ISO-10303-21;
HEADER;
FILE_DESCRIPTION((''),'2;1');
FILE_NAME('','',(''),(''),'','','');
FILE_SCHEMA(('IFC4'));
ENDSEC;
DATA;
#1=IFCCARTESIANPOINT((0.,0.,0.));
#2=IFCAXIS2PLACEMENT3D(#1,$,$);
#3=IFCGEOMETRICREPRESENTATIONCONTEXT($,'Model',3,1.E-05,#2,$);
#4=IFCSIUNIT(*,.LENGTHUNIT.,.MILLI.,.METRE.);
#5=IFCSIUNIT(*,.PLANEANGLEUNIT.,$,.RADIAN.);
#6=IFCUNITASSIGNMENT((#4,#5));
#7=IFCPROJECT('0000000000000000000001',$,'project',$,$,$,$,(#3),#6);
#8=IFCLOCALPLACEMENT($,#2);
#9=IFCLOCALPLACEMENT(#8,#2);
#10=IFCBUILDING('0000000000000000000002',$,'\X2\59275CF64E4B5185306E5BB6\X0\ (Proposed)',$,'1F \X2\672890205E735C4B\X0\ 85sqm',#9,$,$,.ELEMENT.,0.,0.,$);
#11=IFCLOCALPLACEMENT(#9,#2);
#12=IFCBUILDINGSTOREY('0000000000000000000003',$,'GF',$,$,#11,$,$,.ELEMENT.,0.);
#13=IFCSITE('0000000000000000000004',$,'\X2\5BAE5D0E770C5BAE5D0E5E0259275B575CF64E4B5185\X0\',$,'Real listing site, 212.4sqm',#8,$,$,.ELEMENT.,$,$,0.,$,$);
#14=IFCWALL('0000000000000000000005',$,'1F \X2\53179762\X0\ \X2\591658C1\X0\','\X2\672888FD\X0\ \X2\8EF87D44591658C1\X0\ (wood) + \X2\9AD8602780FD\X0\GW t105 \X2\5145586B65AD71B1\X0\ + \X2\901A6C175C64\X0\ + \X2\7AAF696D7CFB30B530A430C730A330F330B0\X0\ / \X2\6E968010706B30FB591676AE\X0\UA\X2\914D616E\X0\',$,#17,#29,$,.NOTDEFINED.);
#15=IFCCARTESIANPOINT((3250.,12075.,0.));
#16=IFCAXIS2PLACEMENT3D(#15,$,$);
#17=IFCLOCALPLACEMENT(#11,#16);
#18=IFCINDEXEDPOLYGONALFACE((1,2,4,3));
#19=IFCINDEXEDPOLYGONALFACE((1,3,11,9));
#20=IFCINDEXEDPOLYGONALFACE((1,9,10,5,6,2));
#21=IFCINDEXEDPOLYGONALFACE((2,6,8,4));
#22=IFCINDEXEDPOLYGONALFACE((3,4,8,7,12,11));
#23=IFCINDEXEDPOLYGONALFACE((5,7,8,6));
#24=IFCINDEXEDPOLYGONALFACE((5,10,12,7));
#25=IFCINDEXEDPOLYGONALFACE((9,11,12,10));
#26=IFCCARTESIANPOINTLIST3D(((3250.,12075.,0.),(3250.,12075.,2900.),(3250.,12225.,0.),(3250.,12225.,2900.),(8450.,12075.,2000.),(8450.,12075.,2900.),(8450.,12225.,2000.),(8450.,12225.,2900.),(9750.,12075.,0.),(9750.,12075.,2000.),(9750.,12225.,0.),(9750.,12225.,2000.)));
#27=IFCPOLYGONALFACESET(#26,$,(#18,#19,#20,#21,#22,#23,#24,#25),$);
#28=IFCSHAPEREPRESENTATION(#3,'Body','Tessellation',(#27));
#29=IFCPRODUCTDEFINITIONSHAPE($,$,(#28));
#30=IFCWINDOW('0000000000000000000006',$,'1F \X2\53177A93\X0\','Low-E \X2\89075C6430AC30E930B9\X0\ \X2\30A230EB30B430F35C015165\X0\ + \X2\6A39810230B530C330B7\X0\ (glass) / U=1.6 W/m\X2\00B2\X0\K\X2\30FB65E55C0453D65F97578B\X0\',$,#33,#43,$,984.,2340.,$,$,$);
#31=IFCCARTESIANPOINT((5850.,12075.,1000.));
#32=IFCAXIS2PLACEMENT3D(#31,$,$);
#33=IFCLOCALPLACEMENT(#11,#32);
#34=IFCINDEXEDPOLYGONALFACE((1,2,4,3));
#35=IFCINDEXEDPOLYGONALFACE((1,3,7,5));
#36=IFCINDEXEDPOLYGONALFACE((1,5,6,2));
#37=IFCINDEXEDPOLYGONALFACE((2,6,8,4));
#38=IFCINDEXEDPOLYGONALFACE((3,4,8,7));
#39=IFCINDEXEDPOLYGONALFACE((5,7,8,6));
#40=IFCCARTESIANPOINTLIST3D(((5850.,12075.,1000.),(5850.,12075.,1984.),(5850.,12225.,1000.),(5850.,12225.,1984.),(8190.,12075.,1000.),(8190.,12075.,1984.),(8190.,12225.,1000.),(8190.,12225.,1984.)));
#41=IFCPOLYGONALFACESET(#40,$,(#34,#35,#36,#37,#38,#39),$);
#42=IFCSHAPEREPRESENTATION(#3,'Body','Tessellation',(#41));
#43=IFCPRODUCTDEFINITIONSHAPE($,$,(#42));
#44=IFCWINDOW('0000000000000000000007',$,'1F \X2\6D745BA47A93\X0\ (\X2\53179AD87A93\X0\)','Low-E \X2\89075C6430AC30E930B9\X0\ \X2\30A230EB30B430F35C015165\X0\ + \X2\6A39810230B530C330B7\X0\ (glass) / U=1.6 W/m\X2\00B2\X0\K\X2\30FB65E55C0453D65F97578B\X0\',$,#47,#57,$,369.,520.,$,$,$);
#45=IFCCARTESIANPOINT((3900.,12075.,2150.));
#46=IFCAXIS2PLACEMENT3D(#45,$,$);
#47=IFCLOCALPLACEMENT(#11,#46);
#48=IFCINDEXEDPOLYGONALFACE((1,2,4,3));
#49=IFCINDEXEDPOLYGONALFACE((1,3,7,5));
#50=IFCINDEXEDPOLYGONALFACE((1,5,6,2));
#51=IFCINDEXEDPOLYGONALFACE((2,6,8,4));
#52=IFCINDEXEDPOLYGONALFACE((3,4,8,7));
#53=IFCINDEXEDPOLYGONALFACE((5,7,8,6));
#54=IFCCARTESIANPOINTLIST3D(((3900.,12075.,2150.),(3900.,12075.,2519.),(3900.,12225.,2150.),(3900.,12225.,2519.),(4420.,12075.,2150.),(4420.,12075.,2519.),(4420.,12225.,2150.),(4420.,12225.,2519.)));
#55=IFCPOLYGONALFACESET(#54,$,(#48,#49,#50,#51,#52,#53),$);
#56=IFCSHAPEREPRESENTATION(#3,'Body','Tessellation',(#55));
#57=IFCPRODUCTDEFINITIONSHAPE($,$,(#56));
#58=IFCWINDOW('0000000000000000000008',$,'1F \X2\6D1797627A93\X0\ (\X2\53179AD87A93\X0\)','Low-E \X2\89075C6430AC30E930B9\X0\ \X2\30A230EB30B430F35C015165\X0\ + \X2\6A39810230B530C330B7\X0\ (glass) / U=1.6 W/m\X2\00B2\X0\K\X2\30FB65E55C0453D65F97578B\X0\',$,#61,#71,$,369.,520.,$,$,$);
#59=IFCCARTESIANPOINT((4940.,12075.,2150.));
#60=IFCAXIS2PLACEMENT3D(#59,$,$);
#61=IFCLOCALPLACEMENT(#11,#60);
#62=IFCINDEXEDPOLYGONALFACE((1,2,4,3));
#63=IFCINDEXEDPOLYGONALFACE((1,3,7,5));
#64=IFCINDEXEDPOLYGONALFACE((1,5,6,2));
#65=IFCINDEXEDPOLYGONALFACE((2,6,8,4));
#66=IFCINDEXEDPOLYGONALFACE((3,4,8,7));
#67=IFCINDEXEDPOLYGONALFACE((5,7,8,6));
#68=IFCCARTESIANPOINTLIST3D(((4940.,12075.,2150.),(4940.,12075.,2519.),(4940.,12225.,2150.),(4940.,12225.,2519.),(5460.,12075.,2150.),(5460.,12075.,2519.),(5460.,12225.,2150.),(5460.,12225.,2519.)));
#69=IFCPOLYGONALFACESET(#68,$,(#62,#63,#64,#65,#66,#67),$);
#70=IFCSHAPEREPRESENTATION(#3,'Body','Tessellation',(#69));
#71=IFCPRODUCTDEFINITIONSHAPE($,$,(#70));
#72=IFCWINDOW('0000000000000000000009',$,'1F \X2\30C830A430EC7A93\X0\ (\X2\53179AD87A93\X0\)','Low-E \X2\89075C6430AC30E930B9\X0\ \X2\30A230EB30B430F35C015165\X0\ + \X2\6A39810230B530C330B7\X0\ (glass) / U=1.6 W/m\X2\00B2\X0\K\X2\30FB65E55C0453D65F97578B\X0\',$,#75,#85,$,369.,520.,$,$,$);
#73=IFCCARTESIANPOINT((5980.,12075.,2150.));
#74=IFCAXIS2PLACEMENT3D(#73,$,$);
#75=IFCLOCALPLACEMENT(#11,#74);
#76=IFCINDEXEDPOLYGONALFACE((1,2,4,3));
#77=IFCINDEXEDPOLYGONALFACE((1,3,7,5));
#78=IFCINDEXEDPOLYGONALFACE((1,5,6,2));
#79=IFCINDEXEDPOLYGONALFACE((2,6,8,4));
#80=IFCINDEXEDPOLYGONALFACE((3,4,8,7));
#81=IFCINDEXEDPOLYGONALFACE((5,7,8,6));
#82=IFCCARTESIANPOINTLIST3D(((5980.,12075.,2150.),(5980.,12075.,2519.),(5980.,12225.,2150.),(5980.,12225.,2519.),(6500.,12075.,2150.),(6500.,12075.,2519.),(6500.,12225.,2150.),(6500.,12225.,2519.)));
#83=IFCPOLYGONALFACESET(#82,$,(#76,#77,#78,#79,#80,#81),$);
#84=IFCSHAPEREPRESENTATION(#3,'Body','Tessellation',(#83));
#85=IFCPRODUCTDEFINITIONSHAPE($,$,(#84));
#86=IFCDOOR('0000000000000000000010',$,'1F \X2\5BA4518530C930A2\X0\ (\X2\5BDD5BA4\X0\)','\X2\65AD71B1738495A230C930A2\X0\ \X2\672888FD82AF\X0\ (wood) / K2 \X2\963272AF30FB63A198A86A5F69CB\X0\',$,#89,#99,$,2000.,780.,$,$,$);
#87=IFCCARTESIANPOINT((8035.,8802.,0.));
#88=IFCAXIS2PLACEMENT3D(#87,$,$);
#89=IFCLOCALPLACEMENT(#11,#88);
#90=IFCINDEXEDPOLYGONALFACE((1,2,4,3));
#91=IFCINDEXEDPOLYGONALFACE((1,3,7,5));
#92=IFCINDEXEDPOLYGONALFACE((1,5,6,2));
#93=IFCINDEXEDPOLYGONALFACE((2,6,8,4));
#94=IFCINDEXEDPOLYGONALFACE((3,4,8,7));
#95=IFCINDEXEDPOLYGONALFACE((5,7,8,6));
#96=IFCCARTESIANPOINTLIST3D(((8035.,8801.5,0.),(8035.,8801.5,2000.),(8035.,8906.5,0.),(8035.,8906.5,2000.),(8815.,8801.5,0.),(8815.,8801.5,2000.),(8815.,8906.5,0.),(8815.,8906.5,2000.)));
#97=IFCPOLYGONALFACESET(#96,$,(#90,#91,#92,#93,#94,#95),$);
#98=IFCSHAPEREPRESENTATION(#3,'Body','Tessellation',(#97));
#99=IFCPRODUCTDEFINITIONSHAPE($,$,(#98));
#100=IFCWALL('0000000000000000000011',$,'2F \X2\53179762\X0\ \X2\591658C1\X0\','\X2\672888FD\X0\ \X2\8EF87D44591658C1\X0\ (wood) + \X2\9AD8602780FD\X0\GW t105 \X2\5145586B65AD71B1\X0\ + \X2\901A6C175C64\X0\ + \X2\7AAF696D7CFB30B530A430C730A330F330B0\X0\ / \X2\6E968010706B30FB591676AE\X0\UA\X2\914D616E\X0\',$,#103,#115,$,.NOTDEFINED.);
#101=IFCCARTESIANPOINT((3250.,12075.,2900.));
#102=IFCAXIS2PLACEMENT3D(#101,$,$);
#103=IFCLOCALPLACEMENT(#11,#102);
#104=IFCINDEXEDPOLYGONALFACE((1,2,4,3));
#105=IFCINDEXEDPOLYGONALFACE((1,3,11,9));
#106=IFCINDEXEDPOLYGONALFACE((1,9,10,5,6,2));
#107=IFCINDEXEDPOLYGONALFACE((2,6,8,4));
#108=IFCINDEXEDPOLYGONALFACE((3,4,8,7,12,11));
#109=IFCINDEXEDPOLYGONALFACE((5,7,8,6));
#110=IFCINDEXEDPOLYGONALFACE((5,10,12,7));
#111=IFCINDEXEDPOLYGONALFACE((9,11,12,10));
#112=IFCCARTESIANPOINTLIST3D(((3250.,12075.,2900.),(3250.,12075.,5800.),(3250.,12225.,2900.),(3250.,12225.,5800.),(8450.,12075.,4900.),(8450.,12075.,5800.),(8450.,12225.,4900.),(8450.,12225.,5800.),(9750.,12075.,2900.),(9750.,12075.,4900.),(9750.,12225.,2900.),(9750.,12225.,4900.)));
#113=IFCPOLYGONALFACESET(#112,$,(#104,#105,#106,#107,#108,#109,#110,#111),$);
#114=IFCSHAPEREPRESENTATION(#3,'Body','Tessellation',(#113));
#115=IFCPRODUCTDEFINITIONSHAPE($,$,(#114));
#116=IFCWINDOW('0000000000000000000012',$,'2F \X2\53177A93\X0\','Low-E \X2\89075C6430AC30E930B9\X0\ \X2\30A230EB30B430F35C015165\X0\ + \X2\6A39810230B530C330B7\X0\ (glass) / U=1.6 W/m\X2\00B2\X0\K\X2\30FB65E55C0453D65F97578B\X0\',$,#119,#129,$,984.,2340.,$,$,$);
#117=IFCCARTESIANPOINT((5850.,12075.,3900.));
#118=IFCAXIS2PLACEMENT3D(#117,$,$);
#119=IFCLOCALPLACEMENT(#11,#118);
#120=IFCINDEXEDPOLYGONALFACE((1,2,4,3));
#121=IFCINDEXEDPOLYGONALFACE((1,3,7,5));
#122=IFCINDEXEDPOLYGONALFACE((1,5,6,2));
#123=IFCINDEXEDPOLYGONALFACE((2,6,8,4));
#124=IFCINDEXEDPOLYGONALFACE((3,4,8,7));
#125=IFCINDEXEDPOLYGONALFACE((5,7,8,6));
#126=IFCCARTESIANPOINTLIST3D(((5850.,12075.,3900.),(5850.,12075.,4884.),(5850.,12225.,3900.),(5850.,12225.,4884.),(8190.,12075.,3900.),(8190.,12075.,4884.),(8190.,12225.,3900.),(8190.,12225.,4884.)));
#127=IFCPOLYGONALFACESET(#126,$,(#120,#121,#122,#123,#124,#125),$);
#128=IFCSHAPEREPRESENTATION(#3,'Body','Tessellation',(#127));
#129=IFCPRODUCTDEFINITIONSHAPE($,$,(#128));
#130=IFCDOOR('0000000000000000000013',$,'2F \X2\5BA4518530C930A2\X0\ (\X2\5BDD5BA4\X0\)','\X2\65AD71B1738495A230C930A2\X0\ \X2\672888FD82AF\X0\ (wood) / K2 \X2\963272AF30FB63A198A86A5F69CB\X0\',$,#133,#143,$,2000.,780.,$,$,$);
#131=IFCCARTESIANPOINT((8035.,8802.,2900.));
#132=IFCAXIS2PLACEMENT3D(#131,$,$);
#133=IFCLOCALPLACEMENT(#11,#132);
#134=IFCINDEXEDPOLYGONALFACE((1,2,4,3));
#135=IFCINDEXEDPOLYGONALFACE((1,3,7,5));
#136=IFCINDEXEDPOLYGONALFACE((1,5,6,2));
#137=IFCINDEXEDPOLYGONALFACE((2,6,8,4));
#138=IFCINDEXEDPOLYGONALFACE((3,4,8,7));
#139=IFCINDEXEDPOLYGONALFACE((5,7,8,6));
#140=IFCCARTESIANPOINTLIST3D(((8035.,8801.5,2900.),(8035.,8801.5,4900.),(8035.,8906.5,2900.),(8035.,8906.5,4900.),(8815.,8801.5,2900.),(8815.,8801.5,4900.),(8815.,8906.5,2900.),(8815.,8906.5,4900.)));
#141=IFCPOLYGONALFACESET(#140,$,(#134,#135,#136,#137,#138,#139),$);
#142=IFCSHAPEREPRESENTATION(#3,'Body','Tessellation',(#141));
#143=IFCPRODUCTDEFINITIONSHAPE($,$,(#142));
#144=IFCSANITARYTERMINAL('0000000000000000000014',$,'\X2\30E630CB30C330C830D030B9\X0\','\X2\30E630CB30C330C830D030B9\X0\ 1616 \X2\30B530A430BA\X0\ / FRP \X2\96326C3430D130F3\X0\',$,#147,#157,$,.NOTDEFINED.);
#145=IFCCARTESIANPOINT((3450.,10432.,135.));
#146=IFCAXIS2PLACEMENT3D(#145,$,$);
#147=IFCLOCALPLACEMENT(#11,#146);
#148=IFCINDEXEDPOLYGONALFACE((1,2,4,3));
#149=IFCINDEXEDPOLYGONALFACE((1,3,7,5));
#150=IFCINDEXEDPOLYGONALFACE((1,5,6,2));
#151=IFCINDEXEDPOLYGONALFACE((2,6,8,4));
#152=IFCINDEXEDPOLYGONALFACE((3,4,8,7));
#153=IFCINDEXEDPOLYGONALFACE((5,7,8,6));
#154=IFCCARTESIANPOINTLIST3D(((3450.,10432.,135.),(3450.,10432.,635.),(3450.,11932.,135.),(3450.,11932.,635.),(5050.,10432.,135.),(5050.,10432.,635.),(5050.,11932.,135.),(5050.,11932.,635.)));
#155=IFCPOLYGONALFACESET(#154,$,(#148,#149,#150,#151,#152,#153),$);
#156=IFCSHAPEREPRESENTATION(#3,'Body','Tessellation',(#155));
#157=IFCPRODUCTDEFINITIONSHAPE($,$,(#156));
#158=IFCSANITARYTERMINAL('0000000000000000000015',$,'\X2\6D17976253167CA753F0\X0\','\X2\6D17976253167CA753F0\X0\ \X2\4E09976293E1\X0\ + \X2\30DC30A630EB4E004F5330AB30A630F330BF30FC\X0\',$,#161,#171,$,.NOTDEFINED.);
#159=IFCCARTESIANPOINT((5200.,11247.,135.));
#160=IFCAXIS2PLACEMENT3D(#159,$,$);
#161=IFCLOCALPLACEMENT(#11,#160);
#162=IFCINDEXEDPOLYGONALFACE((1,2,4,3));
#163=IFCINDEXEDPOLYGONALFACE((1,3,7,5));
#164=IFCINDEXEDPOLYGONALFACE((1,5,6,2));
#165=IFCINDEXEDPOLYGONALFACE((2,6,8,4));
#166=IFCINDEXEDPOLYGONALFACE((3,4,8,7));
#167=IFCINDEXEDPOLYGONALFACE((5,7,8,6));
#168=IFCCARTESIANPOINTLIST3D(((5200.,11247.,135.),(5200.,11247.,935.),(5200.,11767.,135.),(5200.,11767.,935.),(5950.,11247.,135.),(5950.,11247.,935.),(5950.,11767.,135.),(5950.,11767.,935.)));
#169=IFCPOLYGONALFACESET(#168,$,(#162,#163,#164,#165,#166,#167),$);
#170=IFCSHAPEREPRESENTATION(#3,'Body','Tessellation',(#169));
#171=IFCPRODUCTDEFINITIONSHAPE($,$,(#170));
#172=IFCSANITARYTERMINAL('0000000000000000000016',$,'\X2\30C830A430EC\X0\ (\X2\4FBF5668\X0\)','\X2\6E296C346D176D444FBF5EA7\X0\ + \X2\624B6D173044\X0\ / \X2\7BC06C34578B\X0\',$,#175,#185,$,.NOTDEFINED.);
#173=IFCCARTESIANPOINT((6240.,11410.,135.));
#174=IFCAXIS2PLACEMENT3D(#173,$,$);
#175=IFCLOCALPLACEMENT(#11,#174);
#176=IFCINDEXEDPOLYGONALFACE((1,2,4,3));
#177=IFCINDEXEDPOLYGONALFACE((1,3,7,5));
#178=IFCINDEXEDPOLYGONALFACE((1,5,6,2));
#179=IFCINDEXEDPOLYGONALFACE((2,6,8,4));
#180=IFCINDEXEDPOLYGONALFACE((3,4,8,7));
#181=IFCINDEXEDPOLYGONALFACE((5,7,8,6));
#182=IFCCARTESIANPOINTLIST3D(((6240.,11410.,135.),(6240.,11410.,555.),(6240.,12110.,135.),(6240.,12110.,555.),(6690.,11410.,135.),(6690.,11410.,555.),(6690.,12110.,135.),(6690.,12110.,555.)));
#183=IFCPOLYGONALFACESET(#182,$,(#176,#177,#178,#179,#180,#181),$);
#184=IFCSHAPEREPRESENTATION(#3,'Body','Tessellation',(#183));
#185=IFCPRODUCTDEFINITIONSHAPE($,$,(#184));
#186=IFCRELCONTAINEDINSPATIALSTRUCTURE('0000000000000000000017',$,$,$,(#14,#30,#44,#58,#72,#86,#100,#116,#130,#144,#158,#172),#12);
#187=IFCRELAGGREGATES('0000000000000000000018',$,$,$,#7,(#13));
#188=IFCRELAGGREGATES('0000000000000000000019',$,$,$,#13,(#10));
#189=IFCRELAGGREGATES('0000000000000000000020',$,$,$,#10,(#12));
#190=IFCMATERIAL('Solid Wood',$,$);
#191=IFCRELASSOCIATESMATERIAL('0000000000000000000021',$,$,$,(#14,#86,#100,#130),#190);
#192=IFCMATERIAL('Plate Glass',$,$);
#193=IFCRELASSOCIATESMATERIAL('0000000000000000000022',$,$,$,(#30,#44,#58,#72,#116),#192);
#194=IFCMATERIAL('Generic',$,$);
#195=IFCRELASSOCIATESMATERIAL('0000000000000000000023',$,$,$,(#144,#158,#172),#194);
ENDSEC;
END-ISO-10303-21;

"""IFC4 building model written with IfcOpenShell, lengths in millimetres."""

from ifc_helpers import new_model, si_unit, frame, frame_2d, origin, place, context, project, spatial, rectangle, extrude, material, element, fill, save


model = new_model("IFC4")

# Units and contexts
model_context = context("Model", 3, precision=1e-05, world=origin())
ifc_project = project(units=[si_unit("LENGTHUNIT", "METRE", prefix="MILLI"), si_unit("PLANEANGLEUNIT", "RADIAN")], contexts=[model_context])

# Site, building, storey
site_placement = place(None, origin())
site = spatial("IfcSite", under=ifc_project, at=site_placement, Name="宮崎県宮崎市大字島之内", ObjectType="Real listing site, 212.4sqm", CompositionType="ELEMENT", RefElevation=0.0)
building_placement = place(site_placement, origin())
building = spatial("IfcBuilding", under=site, at=building_placement, Name="大島之内の家 (Proposed)", ObjectType="1F 木造平屋 85sqm", CompositionType="ELEMENT", ElevationOfRefHeight=0.0, ElevationOfTerrain=0.0)
storey_placement = place(building_placement, origin())
storey = spatial("IfcBuildingStorey", under=building, at=storey_placement, Name="GF", CompositionType="ELEMENT", Elevation=0.0)

# Wall, openings, windows
ifc_material_1 = material(Name="Solid Wood")
wall_1_placement = place(storey_placement, frame((3250.0, 12075.0, 0.0)))
wall_1 = element("IfcWall", 1, at=wall_1_placement, inside=storey, material=ifc_material_1, Name="1F 北面 外壁", Description="木製 軸組外壁 (wood) + 高性能GW t105 充填断熱 + 通気層 + 窯業系サイディング / 準耐火・外皮UA配慮", PredefinedType="NOTDEFINED", context=model_context, shape_type="SweptSolid", body=[
    extrude(rectangle(XDim=6500.0, YDim=150.0, at=frame_2d((3250.0, 75.0))), frame((3250.0, 12075.0, 0.0)), (0.0, 0.0, 1.0), 2900.0),
])
opening_1_placement = place(storey_placement, frame((5850.0, 12075.0, 1000.0)))
opening_1 = element("IfcOpeningElement", 2, at=opening_1_placement, cuts=wall_1, PredefinedType="NOTDEFINED", context=model_context, shape_type="SweptSolid", body=[
    extrude(rectangle(XDim=2340.0, YDim=150.0, at=frame_2d((1170.0, 75.0))), frame((5850.0, 12075.0, 1000.0)), (0.0, 0.0, 1.0), 984.0),
])
opening_2_placement = place(storey_placement, frame((3900.0, 12075.0, 2150.0)))
opening_2 = element("IfcOpeningElement", 3, at=opening_2_placement, cuts=wall_1, PredefinedType="NOTDEFINED", context=model_context, shape_type="SweptSolid", body=[
    extrude(rectangle(XDim=520.0, YDim=150.0, at=frame_2d((260.0, 75.0))), frame((3900.0, 12075.0, 2150.0)), (0.0, 0.0, 1.0), 369.0),
])
opening_3_placement = place(storey_placement, frame((4940.0, 12075.0, 2150.0)))
opening_3 = element("IfcOpeningElement", 4, at=opening_3_placement, cuts=wall_1, PredefinedType="NOTDEFINED", context=model_context, shape_type="SweptSolid", body=[
    extrude(rectangle(XDim=520.0, YDim=150.0, at=frame_2d((260.0, 75.0))), frame((4940.0, 12075.0, 2150.0)), (0.0, 0.0, 1.0), 369.0),
])
opening_4_placement = place(storey_placement, frame((5980.0, 12075.0, 2150.0)))
opening_4 = element("IfcOpeningElement", 5, at=opening_4_placement, cuts=wall_1, PredefinedType="NOTDEFINED", context=model_context, shape_type="SweptSolid", body=[
    extrude(rectangle(XDim=520.0, YDim=150.0, at=frame_2d((260.0, 75.0))), frame((5980.0, 12075.0, 2150.0)), (0.0, 0.0, 1.0), 369.0),
])
ifc_material_2 = material(Name="Plate Glass")
window_1_placement = place(storey_placement, frame((5850.0, 12075.0, 1000.0)))
window_1 = element("IfcWindow", 6, at=window_1_placement, inside=storey, material=ifc_material_2, Name="1F 北窓", Description="Low-E 複層ガラス アルゴン封入 + 樹脂サッシ (glass) / U=1.6 W/m²K・日射取得型", OverallHeight=984.0, OverallWidth=2340.0, context=model_context, shape_type="SweptSolid", body=[
    extrude(rectangle(XDim=2340.0, YDim=150.0, at=frame_2d((1170.0, 75.0))), frame((5850.0, 12075.0, 1000.0)), (0.0, 0.0, 1.0), 984.0),
])
fill(opening_1, window_1)
window_2_placement = place(storey_placement, frame((3900.0, 12075.0, 2150.0)))
window_2 = element("IfcWindow", 7, at=window_2_placement, inside=storey, material=ifc_material_2, Name="1F 浴室窓 (北高窓)", Description="Low-E 複層ガラス アルゴン封入 + 樹脂サッシ (glass) / U=1.6 W/m²K・日射取得型", OverallHeight=369.0, OverallWidth=520.0, context=model_context, shape_type="SweptSolid", body=[
    extrude(rectangle(XDim=520.0, YDim=150.0, at=frame_2d((260.0, 75.0))), frame((3900.0, 12075.0, 2150.0)), (0.0, 0.0, 1.0), 369.0),
])
fill(opening_2, window_2)
window_3_placement = place(storey_placement, frame((4940.0, 12075.0, 2150.0)))
window_3 = element("IfcWindow", 8, at=window_3_placement, inside=storey, material=ifc_material_2, Name="1F 洗面窓 (北高窓)", Description="Low-E 複層ガラス アルゴン封入 + 樹脂サッシ (glass) / U=1.6 W/m²K・日射取得型", OverallHeight=369.0, OverallWidth=520.0, context=model_context, shape_type="SweptSolid", body=[
    extrude(rectangle(XDim=520.0, YDim=150.0, at=frame_2d((260.0, 75.0))), frame((4940.0, 12075.0, 2150.0)), (0.0, 0.0, 1.0), 369.0),
])
fill(opening_3, window_3)
window_4_placement = place(storey_placement, frame((5980.0, 12075.0, 2150.0)))
window_4 = element("IfcWindow", 9, at=window_4_placement, inside=storey, material=ifc_material_2, Name="1F トイレ窓 (北高窓)", Description="Low-E 複層ガラス アルゴン封入 + 樹脂サッシ (glass) / U=1.6 W/m²K・日射取得型", OverallHeight=369.0, OverallWidth=520.0, context=model_context, shape_type="SweptSolid", body=[
    extrude(rectangle(XDim=520.0, YDim=150.0, at=frame_2d((260.0, 75.0))), frame((5980.0, 12075.0, 2150.0)), (0.0, 0.0, 1.0), 369.0),
])
fill(opening_4, window_4)

# Door
door_1_placement = place(storey_placement, frame((8035.0, 8802.0, 0.0)))
element("IfcDoor", 10, at=door_1_placement, inside=storey, material=ifc_material_1, Name="1F 室内ドア (寝室)", Description="断熱玄関ドア 木製芯 (wood) / K2 防犯・採風機構", OverallHeight=2000.0, OverallWidth=780.0, context=model_context, shape_type="SweptSolid", body=[
    extrude(rectangle(XDim=780.0, YDim=105.0, at=frame_2d((390.0, 52.0))), frame((8035.0, 8802.0, 0.0)), (0.0, 0.0, 1.0), 2000.0),
])

# Wall, opening, window
wall_2_placement = place(storey_placement, frame((3250.0, 12075.0, 2900.0)))
wall_2 = element("IfcWall", 11, at=wall_2_placement, inside=storey, material=ifc_material_1, Name="2F 北面 外壁", Description="木製 軸組外壁 (wood) + 高性能GW t105 充填断熱 + 通気層 + 窯業系サイディング / 準耐火・外皮UA配慮", PredefinedType="NOTDEFINED", context=model_context, shape_type="SweptSolid", body=[
    extrude(rectangle(XDim=6500.0, YDim=150.0, at=frame_2d((3250.0, 75.0))), frame((3250.0, 12075.0, 2900.0)), (0.0, 0.0, 1.0), 2900.0),
])
opening_5_placement = place(storey_placement, frame((5850.0, 12075.0, 3900.0)))
opening_5 = element("IfcOpeningElement", 12, at=opening_5_placement, cuts=wall_2, PredefinedType="NOTDEFINED", context=model_context, shape_type="SweptSolid", body=[
    extrude(rectangle(XDim=2340.0, YDim=150.0, at=frame_2d((1170.0, 75.0))), frame((5850.0, 12075.0, 3900.0)), (0.0, 0.0, 1.0), 984.0),
])
window_5_placement = place(storey_placement, frame((5850.0, 12075.0, 3900.0)))
window_5 = element("IfcWindow", 13, at=window_5_placement, inside=storey, material=ifc_material_2, Name="2F 北窓", Description="Low-E 複層ガラス アルゴン封入 + 樹脂サッシ (glass) / U=1.6 W/m²K・日射取得型", OverallHeight=984.0, OverallWidth=2340.0, context=model_context, shape_type="SweptSolid", body=[
    extrude(rectangle(XDim=2340.0, YDim=150.0, at=frame_2d((1170.0, 75.0))), frame((5850.0, 12075.0, 3900.0)), (0.0, 0.0, 1.0), 984.0),
])
fill(opening_5, window_5)

# Door
door_2_placement = place(storey_placement, frame((8035.0, 8802.0, 2900.0)))
element("IfcDoor", 14, at=door_2_placement, inside=storey, material=ifc_material_1, Name="2F 室内ドア (寝室)", Description="断熱玄関ドア 木製芯 (wood) / K2 防犯・採風機構", OverallHeight=2000.0, OverallWidth=780.0, context=model_context, shape_type="SweptSolid", body=[
    extrude(rectangle(XDim=780.0, YDim=105.0, at=frame_2d((390.0, 52.0))), frame((8035.0, 8802.0, 2900.0)), (0.0, 0.0, 1.0), 2000.0),
])

# Sanitary terminals
ifc_material_3 = material(Name="Generic")
sanitary_terminal_1_placement = place(storey_placement, frame((3450.0, 10432.0, 135.0)))
element("IfcSanitaryTerminal", 15, at=sanitary_terminal_1_placement, inside=storey, material=ifc_material_3, Name="ユニットバス", Description="ユニットバス 1616 サイズ / FRP 防水パン", PredefinedType="NOTDEFINED", context=model_context, shape_type="SweptSolid", body=[
    extrude(rectangle(XDim=1600.0, YDim=1500.0, at=frame_2d((800.0, 750.0))), frame((3450.0, 10432.0, 135.0)), (0.0, 0.0, 1.0), 500.0),
])
sanitary_terminal_2_placement = place(storey_placement, frame((5200.0, 11247.0, 135.0)))
element("IfcSanitaryTerminal", 16, at=sanitary_terminal_2_placement, inside=storey, material=ifc_material_3, Name="洗面化粧台", Description="洗面化粧台 三面鏡 + ボウル一体カウンター", PredefinedType="NOTDEFINED", context=model_context, shape_type="SweptSolid", body=[
    extrude(rectangle(XDim=750.0, YDim=520.0, at=frame_2d((375.0, 260.0))), frame((5200.0, 11247.0, 135.0)), (0.0, 0.0, 1.0), 800.0),
])
sanitary_terminal_3_placement = place(storey_placement, frame((6240.0, 11410.0, 135.0)))
element("IfcSanitaryTerminal", 17, at=sanitary_terminal_3_placement, inside=storey, material=ifc_material_3, Name="トイレ (便器)", Description="温水洗浄便座 + 手洗い / 節水型", PredefinedType="NOTDEFINED", context=model_context, shape_type="SweptSolid", body=[
    extrude(rectangle(XDim=450.0, YDim=700.0, at=frame_2d((225.0, 350.0))), frame((6240.0, 11410.0, 135.0)), (0.0, 0.0, 1.0), 420.0),
])

save(model, "model.ifc")
